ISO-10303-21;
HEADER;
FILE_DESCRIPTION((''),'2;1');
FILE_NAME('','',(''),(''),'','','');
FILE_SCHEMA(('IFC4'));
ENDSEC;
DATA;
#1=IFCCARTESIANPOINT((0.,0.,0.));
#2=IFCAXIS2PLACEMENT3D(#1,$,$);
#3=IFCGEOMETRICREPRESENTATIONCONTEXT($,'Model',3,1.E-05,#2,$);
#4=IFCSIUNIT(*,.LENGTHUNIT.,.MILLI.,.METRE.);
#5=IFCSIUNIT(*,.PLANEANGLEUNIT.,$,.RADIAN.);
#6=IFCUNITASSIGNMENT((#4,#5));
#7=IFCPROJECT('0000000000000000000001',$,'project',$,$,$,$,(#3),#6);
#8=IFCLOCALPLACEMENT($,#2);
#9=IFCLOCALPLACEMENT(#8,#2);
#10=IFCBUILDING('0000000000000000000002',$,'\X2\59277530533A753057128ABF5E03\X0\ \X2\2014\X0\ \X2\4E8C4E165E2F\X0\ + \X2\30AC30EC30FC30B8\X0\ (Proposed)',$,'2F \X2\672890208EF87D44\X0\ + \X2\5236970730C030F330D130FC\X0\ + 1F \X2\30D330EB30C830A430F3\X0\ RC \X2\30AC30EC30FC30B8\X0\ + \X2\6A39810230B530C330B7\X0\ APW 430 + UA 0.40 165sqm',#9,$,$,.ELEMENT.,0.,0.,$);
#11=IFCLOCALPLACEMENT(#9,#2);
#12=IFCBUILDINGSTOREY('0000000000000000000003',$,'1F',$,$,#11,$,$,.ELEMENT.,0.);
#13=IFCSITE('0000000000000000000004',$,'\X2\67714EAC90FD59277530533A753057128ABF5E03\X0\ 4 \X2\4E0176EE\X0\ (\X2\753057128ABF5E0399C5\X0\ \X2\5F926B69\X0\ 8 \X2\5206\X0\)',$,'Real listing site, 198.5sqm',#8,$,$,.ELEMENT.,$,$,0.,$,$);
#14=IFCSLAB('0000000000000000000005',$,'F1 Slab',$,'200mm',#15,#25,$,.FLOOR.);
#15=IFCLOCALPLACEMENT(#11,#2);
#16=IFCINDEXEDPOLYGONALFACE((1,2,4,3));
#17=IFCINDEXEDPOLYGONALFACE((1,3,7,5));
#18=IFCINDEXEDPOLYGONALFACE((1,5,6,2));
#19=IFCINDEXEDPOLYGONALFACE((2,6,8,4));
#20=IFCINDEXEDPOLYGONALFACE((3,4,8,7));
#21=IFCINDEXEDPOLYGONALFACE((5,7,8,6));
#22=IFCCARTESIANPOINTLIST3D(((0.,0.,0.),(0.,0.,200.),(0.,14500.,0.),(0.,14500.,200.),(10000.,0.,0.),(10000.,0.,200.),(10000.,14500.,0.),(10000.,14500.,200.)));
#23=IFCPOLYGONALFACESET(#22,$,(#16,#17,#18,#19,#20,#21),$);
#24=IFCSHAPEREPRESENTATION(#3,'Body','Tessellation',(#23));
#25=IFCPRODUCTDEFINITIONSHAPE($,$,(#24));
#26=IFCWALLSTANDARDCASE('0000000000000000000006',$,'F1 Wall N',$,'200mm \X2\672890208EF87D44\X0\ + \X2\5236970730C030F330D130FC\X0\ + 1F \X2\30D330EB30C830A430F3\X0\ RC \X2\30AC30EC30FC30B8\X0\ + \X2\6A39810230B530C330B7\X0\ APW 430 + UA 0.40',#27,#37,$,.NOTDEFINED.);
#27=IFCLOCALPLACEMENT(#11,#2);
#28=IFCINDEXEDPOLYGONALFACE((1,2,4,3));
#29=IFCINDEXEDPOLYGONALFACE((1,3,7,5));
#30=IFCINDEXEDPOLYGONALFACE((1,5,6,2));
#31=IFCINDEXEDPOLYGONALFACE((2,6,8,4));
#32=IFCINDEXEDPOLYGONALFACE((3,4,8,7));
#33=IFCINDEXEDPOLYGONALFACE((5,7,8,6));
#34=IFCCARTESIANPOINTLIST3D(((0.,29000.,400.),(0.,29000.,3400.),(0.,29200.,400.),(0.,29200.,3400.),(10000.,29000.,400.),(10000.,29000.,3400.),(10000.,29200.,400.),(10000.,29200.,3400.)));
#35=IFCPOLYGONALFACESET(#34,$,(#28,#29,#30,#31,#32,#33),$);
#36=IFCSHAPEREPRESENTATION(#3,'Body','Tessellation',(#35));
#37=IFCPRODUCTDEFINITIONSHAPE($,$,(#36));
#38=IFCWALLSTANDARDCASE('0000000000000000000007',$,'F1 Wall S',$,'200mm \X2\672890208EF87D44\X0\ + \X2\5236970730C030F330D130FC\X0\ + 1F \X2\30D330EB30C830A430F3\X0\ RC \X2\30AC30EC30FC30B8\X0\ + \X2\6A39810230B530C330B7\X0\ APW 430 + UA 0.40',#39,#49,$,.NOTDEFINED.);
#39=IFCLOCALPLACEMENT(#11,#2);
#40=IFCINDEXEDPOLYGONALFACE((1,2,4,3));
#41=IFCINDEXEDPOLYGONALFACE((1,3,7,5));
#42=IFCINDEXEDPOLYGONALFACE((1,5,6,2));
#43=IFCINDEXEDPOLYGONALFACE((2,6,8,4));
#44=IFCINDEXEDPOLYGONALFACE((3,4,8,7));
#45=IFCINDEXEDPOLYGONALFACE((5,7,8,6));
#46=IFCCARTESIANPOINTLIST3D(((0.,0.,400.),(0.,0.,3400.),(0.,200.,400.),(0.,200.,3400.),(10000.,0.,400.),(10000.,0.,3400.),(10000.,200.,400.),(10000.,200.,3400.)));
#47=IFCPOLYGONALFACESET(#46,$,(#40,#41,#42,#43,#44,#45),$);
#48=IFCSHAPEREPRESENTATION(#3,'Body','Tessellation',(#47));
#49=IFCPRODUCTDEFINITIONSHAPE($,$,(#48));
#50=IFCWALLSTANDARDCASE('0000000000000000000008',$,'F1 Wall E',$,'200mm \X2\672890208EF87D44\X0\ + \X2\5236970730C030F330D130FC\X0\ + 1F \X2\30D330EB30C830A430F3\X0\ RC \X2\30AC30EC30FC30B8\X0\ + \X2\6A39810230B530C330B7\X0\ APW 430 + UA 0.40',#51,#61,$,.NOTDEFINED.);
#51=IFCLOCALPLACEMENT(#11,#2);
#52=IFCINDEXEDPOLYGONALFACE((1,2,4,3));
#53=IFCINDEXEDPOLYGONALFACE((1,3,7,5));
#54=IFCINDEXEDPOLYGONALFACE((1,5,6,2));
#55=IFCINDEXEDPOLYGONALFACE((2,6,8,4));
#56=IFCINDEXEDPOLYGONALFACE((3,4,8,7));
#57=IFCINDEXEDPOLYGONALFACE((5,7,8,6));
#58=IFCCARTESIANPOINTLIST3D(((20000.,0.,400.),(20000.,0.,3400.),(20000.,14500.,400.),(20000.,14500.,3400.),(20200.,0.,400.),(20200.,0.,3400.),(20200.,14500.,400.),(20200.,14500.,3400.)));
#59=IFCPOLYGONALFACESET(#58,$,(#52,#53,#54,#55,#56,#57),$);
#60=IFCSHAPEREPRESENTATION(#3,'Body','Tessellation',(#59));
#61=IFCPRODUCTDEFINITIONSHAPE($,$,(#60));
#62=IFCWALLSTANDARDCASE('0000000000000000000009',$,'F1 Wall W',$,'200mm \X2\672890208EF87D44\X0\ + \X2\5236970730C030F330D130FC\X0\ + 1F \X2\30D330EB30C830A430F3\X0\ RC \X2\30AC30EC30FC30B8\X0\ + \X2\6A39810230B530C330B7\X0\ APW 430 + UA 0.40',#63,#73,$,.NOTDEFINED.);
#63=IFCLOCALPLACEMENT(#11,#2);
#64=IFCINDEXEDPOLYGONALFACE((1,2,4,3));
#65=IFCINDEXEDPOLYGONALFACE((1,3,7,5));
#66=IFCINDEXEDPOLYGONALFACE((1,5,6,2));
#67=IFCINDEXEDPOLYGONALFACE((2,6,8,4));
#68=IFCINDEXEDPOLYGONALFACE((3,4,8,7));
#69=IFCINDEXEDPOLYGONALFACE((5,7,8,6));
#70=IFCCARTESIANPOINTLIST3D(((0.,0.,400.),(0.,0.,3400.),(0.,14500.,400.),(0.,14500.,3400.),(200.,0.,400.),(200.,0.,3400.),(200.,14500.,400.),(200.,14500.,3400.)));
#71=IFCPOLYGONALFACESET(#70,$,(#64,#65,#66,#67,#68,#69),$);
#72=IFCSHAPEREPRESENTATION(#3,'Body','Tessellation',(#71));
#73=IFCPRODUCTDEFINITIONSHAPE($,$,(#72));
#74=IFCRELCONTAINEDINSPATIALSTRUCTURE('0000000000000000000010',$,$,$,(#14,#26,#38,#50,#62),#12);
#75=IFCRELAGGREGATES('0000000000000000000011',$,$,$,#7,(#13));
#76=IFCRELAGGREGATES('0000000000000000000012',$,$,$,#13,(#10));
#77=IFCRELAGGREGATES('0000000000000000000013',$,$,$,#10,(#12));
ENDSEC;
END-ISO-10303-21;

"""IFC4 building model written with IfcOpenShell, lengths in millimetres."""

from ifc_helpers import new_model, si_unit, frame, frame_2d, origin, place, context, project, spatial, rectangle, extrude, element, save


model = new_model("IFC4")

# Units and contexts
model_context = context("Model", 3, precision=1e-05, world=origin())
ifc_project = project(units=[si_unit("LENGTHUNIT", "METRE", prefix="MILLI"), si_unit("PLANEANGLEUNIT", "RADIAN")], contexts=[model_context])

# Site, building, storey
site_placement = place(None, origin())
site = spatial("IfcSite", under=ifc_project, at=site_placement, Name="東京都大田区田園調布 4 丁目 (田園調布駅 徒歩 8 分)", ObjectType="Real listing site, 198.5sqm", CompositionType="ELEMENT", RefElevation=0.0)
building_placement = place(site_placement, origin())
building = spatial("IfcBuilding", under=site, at=building_placement, Name="大田区田園調布 — 二世帯 + ガレージ (Proposed)", ObjectType="2F 木造軸組 + 制震ダンパー + 1F ビルトイン RC ガレージ + 樹脂サッシ APW 430 + UA 0.40 165sqm", CompositionType="ELEMENT", ElevationOfRefHeight=0.0, ElevationOfTerrain=0.0)
storey_placement = place(building_placement, origin())
storey = spatial("IfcBuildingStorey", under=building, at=storey_placement, Name="1F", CompositionType="ELEMENT", Elevation=0.0)

# Slab
slab_placement = place(storey_placement, origin())
element("IfcSlab", 1, at=slab_placement, inside=storey, Name="F1 Slab", ObjectType="200mm", PredefinedType="FLOOR", context=model_context, shape_type="SweptSolid", body=[
    extrude(rectangle(XDim=10000.0, YDim=14500.0, at=frame_2d((5000.0, 7250.0))), origin(), (0.0, 0.0, 1.0), 200.0),
])

# Walls
wall_1_placement = place(storey_placement, frame((0.0, 14500.0, 200.0)))
element("IfcWallStandardCase", 2, at=wall_1_placement, inside=storey, Name="F1 Wall N", ObjectType="200mm 木造軸組 + 制震ダンパー + 1F ビルトイン RC ガレージ + 樹脂サッシ APW 430 + UA 0.40", PredefinedType="NOTDEFINED", context=model_context, shape_type="SweptSolid", body=[
    extrude(rectangle(XDim=10000.0, YDim=200.0, at=frame_2d((5000.0, 100.0))), frame((0.0, 14500.0, 200.0)), (0.0, 0.0, 1.0), 3000.0),
])
wall_2_placement = place(storey_placement, frame((0.0, 0.0, 200.0)))
element("IfcWallStandardCase", 3, at=wall_2_placement, inside=storey, Name="F1 Wall S", ObjectType="200mm 木造軸組 + 制震ダンパー + 1F ビルトイン RC ガレージ + 樹脂サッシ APW 430 + UA 0.40", PredefinedType="NOTDEFINED", context=model_context, shape_type="SweptSolid", body=[
    extrude(rectangle(XDim=10000.0, YDim=200.0, at=frame_2d((5000.0, 100.0))), frame((0.0, 0.0, 200.0)), (0.0, 0.0, 1.0), 3000.0),
])
wall_3_placement = place(storey_placement, frame((10000.0, 0.0, 200.0)))
element("IfcWallStandardCase", 4, at=wall_3_placement, inside=storey, Name="F1 Wall E", ObjectType="200mm 木造軸組 + 制震ダンパー + 1F ビルトイン RC ガレージ + 樹脂サッシ APW 430 + UA 0.40", PredefinedType="NOTDEFINED", context=model_context, shape_type="SweptSolid", body=[
    extrude(rectangle(XDim=200.0, YDim=14500.0, at=frame_2d((100.0, 7250.0))), frame((10000.0, 0.0, 200.0)), (0.0, 0.0, 1.0), 3000.0),
])
wall_4_placement = place(storey_placement, frame((0.0, 0.0, 200.0)))
element("IfcWallStandardCase", 5, at=wall_4_placement, inside=storey, Name="F1 Wall W", ObjectType="200mm 木造軸組 + 制震ダンパー + 1F ビルトイン RC ガレージ + 樹脂サッシ APW 430 + UA 0.40", PredefinedType="NOTDEFINED", context=model_context, shape_type="SweptSolid", body=[
    extrude(rectangle(XDim=200.0, YDim=14500.0, at=frame_2d((100.0, 7250.0))), frame((0.0, 0.0, 200.0)), (0.0, 0.0, 1.0), 3000.0),
])

save(model, "model.ifc")
